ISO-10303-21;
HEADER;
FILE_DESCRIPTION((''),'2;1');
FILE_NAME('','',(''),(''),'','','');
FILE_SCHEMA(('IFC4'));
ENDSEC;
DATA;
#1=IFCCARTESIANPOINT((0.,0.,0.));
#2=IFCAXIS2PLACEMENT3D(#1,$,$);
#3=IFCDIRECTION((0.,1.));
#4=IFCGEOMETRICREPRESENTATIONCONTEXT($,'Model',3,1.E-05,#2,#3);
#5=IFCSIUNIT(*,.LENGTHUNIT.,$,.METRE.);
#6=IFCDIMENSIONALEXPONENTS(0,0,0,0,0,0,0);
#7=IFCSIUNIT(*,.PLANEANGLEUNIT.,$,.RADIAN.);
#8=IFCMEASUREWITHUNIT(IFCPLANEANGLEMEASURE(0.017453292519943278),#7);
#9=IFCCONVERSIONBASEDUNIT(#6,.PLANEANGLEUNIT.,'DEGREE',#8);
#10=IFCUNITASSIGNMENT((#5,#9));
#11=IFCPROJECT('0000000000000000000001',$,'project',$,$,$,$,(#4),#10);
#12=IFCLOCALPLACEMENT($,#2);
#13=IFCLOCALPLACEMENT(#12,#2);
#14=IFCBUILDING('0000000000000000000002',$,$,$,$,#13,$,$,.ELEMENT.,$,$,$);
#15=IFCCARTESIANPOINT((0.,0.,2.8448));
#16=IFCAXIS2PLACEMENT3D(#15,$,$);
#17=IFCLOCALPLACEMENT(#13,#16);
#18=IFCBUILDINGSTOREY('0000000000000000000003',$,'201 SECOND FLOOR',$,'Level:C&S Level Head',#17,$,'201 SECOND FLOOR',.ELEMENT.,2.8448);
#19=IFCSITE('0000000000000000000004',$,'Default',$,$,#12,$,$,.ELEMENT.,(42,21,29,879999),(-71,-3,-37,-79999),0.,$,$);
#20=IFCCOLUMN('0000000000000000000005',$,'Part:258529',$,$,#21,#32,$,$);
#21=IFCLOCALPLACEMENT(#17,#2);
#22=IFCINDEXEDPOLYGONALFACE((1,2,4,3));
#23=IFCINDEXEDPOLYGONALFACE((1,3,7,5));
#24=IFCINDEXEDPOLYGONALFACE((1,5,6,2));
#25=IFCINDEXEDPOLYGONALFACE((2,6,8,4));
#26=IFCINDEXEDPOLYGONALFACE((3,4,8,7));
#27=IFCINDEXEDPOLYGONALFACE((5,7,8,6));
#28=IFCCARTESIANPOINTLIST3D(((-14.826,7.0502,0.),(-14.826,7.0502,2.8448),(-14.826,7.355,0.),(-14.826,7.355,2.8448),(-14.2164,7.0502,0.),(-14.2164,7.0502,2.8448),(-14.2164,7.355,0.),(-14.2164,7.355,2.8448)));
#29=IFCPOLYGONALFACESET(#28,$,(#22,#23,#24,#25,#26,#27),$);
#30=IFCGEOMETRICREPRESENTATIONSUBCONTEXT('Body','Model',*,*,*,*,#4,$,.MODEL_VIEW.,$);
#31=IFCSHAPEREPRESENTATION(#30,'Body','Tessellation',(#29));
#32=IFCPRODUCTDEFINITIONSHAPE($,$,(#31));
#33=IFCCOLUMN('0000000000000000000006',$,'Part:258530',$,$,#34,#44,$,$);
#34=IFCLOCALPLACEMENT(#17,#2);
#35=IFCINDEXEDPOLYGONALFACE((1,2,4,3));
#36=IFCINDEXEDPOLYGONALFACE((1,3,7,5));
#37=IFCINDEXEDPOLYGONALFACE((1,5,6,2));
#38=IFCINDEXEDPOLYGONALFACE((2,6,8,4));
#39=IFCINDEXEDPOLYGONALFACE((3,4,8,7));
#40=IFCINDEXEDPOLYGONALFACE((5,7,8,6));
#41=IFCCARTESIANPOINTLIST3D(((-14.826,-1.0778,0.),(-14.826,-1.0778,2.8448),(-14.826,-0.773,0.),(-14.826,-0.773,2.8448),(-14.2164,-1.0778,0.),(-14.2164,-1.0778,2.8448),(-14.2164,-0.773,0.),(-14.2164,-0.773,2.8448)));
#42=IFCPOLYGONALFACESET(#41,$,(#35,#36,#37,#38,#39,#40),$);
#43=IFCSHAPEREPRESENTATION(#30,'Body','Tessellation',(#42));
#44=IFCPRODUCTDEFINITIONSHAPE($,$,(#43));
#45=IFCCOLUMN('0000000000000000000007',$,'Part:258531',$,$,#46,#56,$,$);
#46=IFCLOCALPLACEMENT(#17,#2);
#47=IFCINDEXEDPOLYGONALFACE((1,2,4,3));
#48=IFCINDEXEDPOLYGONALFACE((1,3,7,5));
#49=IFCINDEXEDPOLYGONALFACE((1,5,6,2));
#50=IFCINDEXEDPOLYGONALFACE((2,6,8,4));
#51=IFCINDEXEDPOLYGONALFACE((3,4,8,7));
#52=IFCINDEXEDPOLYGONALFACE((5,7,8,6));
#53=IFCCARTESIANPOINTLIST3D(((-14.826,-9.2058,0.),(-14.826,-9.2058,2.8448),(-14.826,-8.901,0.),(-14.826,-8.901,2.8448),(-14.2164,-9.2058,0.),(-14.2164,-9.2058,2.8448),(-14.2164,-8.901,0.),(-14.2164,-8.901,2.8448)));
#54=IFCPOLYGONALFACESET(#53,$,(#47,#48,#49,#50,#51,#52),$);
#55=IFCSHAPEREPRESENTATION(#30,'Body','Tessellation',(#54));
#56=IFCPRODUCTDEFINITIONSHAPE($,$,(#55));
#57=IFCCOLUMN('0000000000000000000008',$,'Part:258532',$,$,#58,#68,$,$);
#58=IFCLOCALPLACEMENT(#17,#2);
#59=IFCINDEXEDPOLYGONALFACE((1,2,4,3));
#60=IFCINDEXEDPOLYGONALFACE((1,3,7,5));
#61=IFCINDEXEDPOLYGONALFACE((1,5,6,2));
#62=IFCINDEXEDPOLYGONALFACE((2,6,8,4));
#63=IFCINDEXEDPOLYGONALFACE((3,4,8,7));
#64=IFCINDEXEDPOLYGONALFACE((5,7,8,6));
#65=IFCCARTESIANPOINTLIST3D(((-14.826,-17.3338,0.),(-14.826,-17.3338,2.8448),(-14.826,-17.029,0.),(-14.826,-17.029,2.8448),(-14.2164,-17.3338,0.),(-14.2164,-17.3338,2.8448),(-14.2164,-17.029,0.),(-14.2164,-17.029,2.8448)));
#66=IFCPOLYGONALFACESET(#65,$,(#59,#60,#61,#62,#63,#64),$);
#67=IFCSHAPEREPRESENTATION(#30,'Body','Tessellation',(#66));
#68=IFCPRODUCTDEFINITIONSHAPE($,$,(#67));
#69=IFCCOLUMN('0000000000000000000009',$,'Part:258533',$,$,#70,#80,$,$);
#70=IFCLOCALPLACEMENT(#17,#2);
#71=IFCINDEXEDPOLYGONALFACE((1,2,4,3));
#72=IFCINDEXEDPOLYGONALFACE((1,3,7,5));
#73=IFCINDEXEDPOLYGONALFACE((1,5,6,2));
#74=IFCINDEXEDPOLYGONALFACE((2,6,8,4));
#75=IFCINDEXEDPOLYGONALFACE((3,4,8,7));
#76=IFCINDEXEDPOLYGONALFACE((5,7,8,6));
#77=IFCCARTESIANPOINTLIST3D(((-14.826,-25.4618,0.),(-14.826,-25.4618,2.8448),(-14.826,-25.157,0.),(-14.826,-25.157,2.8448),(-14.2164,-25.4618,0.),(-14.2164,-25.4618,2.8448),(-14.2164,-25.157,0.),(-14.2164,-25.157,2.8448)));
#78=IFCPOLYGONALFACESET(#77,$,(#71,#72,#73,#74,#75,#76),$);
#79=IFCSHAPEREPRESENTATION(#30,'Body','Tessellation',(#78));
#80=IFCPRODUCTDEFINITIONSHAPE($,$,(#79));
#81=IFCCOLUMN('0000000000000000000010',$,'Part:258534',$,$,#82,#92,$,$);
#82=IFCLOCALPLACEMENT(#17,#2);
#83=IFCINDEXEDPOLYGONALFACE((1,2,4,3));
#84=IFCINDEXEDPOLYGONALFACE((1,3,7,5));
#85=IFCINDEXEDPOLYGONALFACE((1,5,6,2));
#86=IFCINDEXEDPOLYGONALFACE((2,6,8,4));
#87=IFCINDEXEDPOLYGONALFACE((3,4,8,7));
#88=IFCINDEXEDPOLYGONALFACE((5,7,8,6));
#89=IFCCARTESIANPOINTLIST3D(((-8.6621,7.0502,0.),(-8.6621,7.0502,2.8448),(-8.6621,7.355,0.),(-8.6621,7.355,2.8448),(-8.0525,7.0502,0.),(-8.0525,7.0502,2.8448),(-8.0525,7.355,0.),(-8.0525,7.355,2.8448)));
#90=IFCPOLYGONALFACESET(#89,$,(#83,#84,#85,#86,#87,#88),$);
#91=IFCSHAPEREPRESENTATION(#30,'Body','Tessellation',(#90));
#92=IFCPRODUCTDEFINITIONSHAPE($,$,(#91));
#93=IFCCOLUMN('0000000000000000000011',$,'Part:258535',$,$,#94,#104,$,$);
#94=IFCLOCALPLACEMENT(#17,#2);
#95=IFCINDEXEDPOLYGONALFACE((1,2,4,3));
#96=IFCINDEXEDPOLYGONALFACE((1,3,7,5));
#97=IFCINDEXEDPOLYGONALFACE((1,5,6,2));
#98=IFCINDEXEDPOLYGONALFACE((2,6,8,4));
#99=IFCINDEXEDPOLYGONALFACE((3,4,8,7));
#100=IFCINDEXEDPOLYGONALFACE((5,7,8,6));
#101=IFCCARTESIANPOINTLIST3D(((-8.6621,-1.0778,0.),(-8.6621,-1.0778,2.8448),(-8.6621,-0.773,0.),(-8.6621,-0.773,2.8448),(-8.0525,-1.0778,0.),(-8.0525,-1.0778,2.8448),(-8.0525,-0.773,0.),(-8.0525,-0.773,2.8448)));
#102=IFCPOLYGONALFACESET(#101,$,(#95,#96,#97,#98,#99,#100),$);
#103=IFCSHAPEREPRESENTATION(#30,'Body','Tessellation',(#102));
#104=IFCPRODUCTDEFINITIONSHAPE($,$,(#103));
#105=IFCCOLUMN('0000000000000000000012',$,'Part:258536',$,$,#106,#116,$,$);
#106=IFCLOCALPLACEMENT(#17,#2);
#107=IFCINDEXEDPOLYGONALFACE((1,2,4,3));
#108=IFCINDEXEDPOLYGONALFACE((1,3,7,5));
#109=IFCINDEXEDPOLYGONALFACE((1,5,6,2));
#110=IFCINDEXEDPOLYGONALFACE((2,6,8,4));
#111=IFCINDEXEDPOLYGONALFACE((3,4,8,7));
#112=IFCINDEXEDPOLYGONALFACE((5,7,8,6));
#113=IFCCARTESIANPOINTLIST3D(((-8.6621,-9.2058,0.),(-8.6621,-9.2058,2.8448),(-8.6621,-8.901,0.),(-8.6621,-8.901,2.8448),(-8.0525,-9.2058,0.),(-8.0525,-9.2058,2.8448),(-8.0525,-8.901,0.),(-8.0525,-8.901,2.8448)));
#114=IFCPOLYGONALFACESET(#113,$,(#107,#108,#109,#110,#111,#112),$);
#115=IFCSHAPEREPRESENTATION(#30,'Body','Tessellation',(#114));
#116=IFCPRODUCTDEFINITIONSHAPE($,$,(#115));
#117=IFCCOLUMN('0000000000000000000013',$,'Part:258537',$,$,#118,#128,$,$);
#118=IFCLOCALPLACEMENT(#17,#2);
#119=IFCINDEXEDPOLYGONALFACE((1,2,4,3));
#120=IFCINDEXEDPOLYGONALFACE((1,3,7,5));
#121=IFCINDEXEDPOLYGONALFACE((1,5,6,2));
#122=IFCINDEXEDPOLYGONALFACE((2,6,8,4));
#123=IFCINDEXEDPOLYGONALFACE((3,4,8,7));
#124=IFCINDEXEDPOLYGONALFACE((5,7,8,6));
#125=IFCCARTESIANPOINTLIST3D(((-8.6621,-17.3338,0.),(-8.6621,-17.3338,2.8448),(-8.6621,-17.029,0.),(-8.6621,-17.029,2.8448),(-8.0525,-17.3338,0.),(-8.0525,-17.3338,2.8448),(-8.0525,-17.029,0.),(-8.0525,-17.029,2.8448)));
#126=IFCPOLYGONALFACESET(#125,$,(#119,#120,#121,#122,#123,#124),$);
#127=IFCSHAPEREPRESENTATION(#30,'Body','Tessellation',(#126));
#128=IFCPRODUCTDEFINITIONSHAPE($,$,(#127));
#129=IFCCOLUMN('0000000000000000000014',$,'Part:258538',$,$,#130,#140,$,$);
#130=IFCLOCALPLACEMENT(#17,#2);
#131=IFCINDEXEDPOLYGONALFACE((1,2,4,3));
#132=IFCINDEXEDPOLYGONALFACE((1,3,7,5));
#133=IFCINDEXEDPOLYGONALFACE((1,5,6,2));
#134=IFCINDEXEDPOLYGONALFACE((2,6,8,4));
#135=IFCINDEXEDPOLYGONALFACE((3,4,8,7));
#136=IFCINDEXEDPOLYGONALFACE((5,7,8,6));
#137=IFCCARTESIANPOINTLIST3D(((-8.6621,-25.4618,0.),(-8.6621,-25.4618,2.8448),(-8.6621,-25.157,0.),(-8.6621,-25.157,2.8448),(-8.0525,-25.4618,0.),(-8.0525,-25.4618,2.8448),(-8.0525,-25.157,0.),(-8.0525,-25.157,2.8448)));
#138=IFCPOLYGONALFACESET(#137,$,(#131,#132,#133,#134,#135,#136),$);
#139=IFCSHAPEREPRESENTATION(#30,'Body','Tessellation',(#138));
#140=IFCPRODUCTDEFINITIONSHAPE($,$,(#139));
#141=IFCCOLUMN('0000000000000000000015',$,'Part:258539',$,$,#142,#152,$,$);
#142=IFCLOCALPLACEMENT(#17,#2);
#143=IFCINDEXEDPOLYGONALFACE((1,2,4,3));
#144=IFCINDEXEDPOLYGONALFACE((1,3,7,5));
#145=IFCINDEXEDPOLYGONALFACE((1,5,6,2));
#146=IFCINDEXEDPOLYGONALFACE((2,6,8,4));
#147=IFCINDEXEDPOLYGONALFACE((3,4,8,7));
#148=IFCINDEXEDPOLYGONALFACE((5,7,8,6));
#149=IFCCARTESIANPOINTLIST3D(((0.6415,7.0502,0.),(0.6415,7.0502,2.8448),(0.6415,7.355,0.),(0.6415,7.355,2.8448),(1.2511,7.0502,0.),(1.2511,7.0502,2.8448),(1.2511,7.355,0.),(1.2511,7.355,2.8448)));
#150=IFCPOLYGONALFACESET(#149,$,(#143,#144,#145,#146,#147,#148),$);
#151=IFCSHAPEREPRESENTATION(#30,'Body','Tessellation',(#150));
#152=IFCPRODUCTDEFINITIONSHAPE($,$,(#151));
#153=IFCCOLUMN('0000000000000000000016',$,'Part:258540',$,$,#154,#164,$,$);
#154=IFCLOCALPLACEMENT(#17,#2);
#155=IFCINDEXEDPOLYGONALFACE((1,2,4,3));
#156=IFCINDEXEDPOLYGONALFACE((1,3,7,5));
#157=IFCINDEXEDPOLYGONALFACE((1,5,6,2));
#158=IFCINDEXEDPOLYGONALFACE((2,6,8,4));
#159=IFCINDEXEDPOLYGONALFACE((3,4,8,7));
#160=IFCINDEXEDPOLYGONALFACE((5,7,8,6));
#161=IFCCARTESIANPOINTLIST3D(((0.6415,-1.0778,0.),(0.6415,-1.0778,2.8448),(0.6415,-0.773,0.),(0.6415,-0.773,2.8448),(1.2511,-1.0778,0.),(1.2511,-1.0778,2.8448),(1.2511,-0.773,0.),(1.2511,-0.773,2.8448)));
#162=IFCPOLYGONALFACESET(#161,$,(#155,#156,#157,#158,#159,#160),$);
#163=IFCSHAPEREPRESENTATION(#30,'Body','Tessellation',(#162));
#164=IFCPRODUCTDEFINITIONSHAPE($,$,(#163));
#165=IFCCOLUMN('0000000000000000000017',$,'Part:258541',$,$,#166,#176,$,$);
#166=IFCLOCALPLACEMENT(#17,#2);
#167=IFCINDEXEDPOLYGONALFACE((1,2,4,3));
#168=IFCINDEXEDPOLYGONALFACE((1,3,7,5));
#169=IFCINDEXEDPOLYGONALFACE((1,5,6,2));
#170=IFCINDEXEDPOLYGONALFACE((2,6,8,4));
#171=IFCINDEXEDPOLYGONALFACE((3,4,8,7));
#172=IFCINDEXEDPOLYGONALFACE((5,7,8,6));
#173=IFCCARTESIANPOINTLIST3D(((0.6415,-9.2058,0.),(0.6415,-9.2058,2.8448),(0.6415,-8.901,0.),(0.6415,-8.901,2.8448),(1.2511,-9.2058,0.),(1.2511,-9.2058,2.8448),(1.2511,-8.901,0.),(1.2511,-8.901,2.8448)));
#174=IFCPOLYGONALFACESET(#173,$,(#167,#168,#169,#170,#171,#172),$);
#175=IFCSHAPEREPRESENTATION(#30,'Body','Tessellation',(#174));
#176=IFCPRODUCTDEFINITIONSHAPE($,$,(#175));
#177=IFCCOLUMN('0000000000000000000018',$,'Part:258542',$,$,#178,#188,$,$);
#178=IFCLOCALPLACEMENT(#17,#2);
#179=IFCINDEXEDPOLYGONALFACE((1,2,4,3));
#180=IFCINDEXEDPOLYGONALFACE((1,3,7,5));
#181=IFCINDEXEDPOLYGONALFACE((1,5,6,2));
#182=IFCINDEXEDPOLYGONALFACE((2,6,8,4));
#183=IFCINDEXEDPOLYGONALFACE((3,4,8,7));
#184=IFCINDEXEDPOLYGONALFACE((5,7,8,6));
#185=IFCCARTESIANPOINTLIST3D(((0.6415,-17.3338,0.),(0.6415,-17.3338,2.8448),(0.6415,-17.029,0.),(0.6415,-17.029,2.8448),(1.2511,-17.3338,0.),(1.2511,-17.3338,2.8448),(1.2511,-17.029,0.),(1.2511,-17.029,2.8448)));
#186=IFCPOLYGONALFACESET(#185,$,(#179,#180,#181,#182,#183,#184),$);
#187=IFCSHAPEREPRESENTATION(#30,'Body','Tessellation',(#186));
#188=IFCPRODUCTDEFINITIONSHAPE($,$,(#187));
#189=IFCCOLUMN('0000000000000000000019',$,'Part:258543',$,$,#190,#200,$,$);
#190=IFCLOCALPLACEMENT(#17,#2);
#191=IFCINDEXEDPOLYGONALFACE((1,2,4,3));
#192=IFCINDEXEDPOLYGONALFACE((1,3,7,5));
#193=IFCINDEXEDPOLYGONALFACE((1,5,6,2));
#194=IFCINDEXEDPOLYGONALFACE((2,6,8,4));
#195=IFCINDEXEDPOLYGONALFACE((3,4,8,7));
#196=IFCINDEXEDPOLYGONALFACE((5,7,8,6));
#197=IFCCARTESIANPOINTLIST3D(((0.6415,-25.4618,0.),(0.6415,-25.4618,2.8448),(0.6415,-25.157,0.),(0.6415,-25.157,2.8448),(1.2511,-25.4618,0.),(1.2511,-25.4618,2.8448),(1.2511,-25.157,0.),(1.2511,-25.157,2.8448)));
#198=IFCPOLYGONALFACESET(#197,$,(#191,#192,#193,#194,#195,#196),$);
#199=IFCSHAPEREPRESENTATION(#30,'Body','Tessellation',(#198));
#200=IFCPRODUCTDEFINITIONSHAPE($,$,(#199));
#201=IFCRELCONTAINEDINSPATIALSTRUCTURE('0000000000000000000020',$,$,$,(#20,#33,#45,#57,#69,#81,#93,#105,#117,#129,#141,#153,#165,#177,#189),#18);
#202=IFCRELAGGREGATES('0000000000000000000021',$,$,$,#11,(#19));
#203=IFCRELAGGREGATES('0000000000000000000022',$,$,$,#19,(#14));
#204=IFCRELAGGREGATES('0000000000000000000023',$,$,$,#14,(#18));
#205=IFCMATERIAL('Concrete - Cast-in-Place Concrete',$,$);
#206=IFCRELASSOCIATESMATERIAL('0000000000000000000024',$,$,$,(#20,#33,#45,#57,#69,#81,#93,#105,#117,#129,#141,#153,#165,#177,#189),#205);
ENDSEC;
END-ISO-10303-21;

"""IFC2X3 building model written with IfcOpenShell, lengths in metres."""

from ifc_helpers import new_model, entity, si_unit, converted_unit, direction, frame, frame_2d, origin, place, context, subcontext, project, spatial, rectangle, extrude, material, element, save


model = new_model("IFC2X3")

# Units and contexts
model_context = context("Model", 3, precision=1e-05, world=origin(), true_north=direction((0.0, 1.0)))
body_context = subcontext(model_context, "Body", "Model", "MODEL_VIEW")
ifc_project = project(units=[si_unit("LENGTHUNIT", "METRE"), converted_unit("PLANEANGLEUNIT", "DEGREE", entity("IfcPlaneAngleMeasure", 0.017453292519943278), si_unit("PLANEANGLEUNIT", "RADIAN"), dimensions=[0, 0, 0, 0, 0, 0, 0])], contexts=[model_context])

# Site, building, storey
site_placement = place(None, origin())
site = spatial("IfcSite", under=ifc_project, at=site_placement, Name="Default", CompositionType="ELEMENT", RefLatitude=(42, 21, 29, 879999), RefLongitude=(-71, -3, -37, -79999), RefElevation=0.0)
building_placement = place(site_placement, origin())
building = spatial("IfcBuilding", under=site, at=building_placement, CompositionType="ELEMENT")
storey_placement = place(building_placement, frame((0.0, 0.0, 2.8448)))
storey = spatial("IfcBuildingStorey", under=building, at=storey_placement, Name="201 SECOND FLOOR", ObjectType="Level:C&S Level Head", LongName="201 SECOND FLOOR", CompositionType="ELEMENT", Elevation=2.8448)

# Columns
ifc_material_1 = material(Name="Concrete - Cast-in-Place Concrete")
column_1_placement = place(storey_placement, origin())
element("IfcColumn", 1, at=column_1_placement, inside=storey, material=ifc_material_1, Name="Part:258529", context=body_context, shape_type="SweptSolid", body=[
    extrude(rectangle(XDim=2.8448, YDim=0.3048, at=frame_2d((0.0, 0.0), x_axis=(1.0, 0.0))), frame((-14.826, 7.2026, 1.4224), z_axis=(1.0, 0.0, 0.0), x_axis=(0.0, 0.0, -1.0)), (0.0, 0.0, 1.0), 0.6096),
])
column_2_placement = place(storey_placement, origin())
element("IfcColumn", 2, at=column_2_placement, inside=storey, material=ifc_material_1, Name="Part:258530", context=body_context, shape_type="SweptSolid", body=[
    extrude(rectangle(XDim=2.8448, YDim=0.3048, at=frame_2d((0.0, 0.0), x_axis=(1.0, 0.0))), frame((-14.826, -0.9254, 1.4224), z_axis=(1.0, 0.0, 0.0), x_axis=(0.0, 0.0, -1.0)), (0.0, 0.0, 1.0), 0.6096),
])
column_3_placement = place(storey_placement, origin())
element("IfcColumn", 3, at=column_3_placement, inside=storey, material=ifc_material_1, Name="Part:258531", context=body_context, shape_type="SweptSolid", body=[
    extrude(rectangle(XDim=2.8448, YDim=0.3048, at=frame_2d((0.0, 0.0), x_axis=(1.0, 0.0))), frame((-14.826, -9.0534, 1.4224), z_axis=(1.0, 0.0, 0.0), x_axis=(0.0, 0.0, -1.0)), (0.0, 0.0, 1.0), 0.6096),
])
column_4_placement = place(storey_placement, origin())
element("IfcColumn", 4, at=column_4_placement, inside=storey, material=ifc_material_1, Name="Part:258532", context=body_context, shape_type="SweptSolid", body=[
    extrude(rectangle(XDim=2.8448, YDim=0.3048, at=frame_2d((0.0, 0.0), x_axis=(1.0, 0.0))), frame((-14.826, -17.1814, 1.4224), z_axis=(1.0, 0.0, 0.0), x_axis=(0.0, 0.0, -1.0)), (0.0, 0.0, 1.0), 0.6096),
])
column_5_placement = place(storey_placement, origin())
element("IfcColumn", 5, at=column_5_placement, inside=storey, material=ifc_material_1, Name="Part:258533", context=body_context, shape_type="SweptSolid", body=[
    extrude(rectangle(XDim=2.8448, YDim=0.3048, at=frame_2d((0.0, 0.0), x_axis=(1.0, 0.0))), frame((-14.826, -25.3094, 1.4224), z_axis=(1.0, 0.0, 0.0), x_axis=(0.0, 0.0, -1.0)), (0.0, 0.0, 1.0), 0.6096),
])
column_6_placement = place(storey_placement, origin())
element("IfcColumn", 6, at=column_6_placement, inside=storey, material=ifc_material_1, Name="Part:258534", context=body_context, shape_type="SweptSolid", body=[
    extrude(rectangle(XDim=2.8448, YDim=0.3048, at=frame_2d((0.0, 0.0), x_axis=(1.0, 0.0))), frame((-8.6621, 7.2026, 1.4224), z_axis=(1.0, 0.0, 0.0), x_axis=(0.0, 0.0, -1.0)), (0.0, 0.0, 1.0), 0.6096),
])
column_7_placement = place(storey_placement, origin())
element("IfcColumn", 7, at=column_7_placement, inside=storey, material=ifc_material_1, Name="Part:258535", context=body_context, shape_type="SweptSolid", body=[
    extrude(rectangle(XDim=2.8448, YDim=0.3048, at=frame_2d((0.0, 0.0), x_axis=(1.0, 0.0))), frame((-8.6621, -0.9254, 1.4224), z_axis=(1.0, 0.0, 0.0), x_axis=(0.0, 0.0, -1.0)), (0.0, 0.0, 1.0), 0.6096),
])
column_8_placement = place(storey_placement, origin())
element("IfcColumn", 8, at=column_8_placement, inside=storey, material=ifc_material_1, Name="Part:258536", context=body_context, shape_type="SweptSolid", body=[
    extrude(rectangle(XDim=2.8448, YDim=0.3048, at=frame_2d((0.0, 0.0), x_axis=(1.0, 0.0))), frame((-8.6621, -9.0534, 1.4224), z_axis=(1.0, 0.0, 0.0), x_axis=(0.0, 0.0, -1.0)), (0.0, 0.0, 1.0), 0.6096),
])
column_9_placement = place(storey_placement, origin())
element("IfcColumn", 9, at=column_9_placement, inside=storey, material=ifc_material_1, Name="Part:258537", context=body_context, shape_type="SweptSolid", body=[
    extrude(rectangle(XDim=2.8448, YDim=0.3048, at=frame_2d((0.0, 0.0), x_axis=(1.0, 0.0))), frame((-8.6621, -17.1814, 1.4224), z_axis=(1.0, 0.0, 0.0), x_axis=(0.0, 0.0, -1.0)), (0.0, 0.0, 1.0), 0.6096),
])
column_10_placement = place(storey_placement, origin())
element("IfcColumn", 10, at=column_10_placement, inside=storey, material=ifc_material_1, Name="Part:258538", context=body_context, shape_type="SweptSolid", body=[
    extrude(rectangle(XDim=2.8448, YDim=0.3048, at=frame_2d((0.0, 0.0), x_axis=(1.0, 0.0))), frame((-8.6621, -25.3094, 1.4224), z_axis=(1.0, 0.0, 0.0), x_axis=(0.0, 0.0, -1.0)), (0.0, 0.0, 1.0), 0.6096),
])
column_11_placement = place(storey_placement, origin())
element("IfcColumn", 11, at=column_11_placement, inside=storey, material=ifc_material_1, Name="Part:258539", context=body_context, shape_type="SweptSolid", body=[
    extrude(rectangle(XDim=2.8448, YDim=0.3048, at=frame_2d((0.0, 0.0), x_axis=(1.0, 0.0))), frame((0.6415, 7.2026, 1.4224), z_axis=(1.0, 0.0, 0.0), x_axis=(0.0, 0.0, -1.0)), (0.0, 0.0, 1.0), 0.6096),
])
column_12_placement = place(storey_placement, origin())
element("IfcColumn", 12, at=column_12_placement, inside=storey, material=ifc_material_1, Name="Part:258540", context=body_context, shape_type="SweptSolid", body=[
    extrude(rectangle(XDim=2.8448, YDim=0.3048, at=frame_2d((0.0, 0.0), x_axis=(1.0, 0.0))), frame((0.6415, -0.9254, 1.4224), z_axis=(1.0, 0.0, 0.0), x_axis=(0.0, 0.0, -1.0)), (0.0, 0.0, 1.0), 0.6096),
])
column_13_placement = place(storey_placement, origin())
element("IfcColumn", 13, at=column_13_placement, inside=storey, material=ifc_material_1, Name="Part:258541", context=body_context, shape_type="SweptSolid", body=[
    extrude(rectangle(XDim=2.8448, YDim=0.3048, at=frame_2d((0.0, 0.0), x_axis=(1.0, 0.0))), frame((0.6415, -9.0534, 1.4224), z_axis=(1.0, 0.0, 0.0), x_axis=(0.0, 0.0, -1.0)), (0.0, 0.0, 1.0), 0.6096),
])
column_14_placement = place(storey_placement, origin())
element("IfcColumn", 14, at=column_14_placement, inside=storey, material=ifc_material_1, Name="Part:258542", context=body_context, shape_type="SweptSolid", body=[
    extrude(rectangle(XDim=2.8448, YDim=0.3048, at=frame_2d((0.0, 0.0), x_axis=(1.0, 0.0))), frame((0.6415, -17.1814, 1.4224), z_axis=(1.0, 0.0, 0.0), x_axis=(0.0, 0.0, -1.0)), (0.0, 0.0, 1.0), 0.6096),
])
column_15_placement = place(storey_placement, origin())
element("IfcColumn", 15, at=column_15_placement, inside=storey, material=ifc_material_1, Name="Part:258543", context=body_context, shape_type="SweptSolid", body=[
    extrude(rectangle(XDim=2.8448, YDim=0.3048, at=frame_2d((0.0, 0.0), x_axis=(1.0, 0.0))), frame((0.6415, -25.3094, 1.4224), z_axis=(1.0, 0.0, 0.0), x_axis=(0.0, 0.0, -1.0)), (0.0, 0.0, 1.0), 0.6096),
])

save(model, "model.ifc")
